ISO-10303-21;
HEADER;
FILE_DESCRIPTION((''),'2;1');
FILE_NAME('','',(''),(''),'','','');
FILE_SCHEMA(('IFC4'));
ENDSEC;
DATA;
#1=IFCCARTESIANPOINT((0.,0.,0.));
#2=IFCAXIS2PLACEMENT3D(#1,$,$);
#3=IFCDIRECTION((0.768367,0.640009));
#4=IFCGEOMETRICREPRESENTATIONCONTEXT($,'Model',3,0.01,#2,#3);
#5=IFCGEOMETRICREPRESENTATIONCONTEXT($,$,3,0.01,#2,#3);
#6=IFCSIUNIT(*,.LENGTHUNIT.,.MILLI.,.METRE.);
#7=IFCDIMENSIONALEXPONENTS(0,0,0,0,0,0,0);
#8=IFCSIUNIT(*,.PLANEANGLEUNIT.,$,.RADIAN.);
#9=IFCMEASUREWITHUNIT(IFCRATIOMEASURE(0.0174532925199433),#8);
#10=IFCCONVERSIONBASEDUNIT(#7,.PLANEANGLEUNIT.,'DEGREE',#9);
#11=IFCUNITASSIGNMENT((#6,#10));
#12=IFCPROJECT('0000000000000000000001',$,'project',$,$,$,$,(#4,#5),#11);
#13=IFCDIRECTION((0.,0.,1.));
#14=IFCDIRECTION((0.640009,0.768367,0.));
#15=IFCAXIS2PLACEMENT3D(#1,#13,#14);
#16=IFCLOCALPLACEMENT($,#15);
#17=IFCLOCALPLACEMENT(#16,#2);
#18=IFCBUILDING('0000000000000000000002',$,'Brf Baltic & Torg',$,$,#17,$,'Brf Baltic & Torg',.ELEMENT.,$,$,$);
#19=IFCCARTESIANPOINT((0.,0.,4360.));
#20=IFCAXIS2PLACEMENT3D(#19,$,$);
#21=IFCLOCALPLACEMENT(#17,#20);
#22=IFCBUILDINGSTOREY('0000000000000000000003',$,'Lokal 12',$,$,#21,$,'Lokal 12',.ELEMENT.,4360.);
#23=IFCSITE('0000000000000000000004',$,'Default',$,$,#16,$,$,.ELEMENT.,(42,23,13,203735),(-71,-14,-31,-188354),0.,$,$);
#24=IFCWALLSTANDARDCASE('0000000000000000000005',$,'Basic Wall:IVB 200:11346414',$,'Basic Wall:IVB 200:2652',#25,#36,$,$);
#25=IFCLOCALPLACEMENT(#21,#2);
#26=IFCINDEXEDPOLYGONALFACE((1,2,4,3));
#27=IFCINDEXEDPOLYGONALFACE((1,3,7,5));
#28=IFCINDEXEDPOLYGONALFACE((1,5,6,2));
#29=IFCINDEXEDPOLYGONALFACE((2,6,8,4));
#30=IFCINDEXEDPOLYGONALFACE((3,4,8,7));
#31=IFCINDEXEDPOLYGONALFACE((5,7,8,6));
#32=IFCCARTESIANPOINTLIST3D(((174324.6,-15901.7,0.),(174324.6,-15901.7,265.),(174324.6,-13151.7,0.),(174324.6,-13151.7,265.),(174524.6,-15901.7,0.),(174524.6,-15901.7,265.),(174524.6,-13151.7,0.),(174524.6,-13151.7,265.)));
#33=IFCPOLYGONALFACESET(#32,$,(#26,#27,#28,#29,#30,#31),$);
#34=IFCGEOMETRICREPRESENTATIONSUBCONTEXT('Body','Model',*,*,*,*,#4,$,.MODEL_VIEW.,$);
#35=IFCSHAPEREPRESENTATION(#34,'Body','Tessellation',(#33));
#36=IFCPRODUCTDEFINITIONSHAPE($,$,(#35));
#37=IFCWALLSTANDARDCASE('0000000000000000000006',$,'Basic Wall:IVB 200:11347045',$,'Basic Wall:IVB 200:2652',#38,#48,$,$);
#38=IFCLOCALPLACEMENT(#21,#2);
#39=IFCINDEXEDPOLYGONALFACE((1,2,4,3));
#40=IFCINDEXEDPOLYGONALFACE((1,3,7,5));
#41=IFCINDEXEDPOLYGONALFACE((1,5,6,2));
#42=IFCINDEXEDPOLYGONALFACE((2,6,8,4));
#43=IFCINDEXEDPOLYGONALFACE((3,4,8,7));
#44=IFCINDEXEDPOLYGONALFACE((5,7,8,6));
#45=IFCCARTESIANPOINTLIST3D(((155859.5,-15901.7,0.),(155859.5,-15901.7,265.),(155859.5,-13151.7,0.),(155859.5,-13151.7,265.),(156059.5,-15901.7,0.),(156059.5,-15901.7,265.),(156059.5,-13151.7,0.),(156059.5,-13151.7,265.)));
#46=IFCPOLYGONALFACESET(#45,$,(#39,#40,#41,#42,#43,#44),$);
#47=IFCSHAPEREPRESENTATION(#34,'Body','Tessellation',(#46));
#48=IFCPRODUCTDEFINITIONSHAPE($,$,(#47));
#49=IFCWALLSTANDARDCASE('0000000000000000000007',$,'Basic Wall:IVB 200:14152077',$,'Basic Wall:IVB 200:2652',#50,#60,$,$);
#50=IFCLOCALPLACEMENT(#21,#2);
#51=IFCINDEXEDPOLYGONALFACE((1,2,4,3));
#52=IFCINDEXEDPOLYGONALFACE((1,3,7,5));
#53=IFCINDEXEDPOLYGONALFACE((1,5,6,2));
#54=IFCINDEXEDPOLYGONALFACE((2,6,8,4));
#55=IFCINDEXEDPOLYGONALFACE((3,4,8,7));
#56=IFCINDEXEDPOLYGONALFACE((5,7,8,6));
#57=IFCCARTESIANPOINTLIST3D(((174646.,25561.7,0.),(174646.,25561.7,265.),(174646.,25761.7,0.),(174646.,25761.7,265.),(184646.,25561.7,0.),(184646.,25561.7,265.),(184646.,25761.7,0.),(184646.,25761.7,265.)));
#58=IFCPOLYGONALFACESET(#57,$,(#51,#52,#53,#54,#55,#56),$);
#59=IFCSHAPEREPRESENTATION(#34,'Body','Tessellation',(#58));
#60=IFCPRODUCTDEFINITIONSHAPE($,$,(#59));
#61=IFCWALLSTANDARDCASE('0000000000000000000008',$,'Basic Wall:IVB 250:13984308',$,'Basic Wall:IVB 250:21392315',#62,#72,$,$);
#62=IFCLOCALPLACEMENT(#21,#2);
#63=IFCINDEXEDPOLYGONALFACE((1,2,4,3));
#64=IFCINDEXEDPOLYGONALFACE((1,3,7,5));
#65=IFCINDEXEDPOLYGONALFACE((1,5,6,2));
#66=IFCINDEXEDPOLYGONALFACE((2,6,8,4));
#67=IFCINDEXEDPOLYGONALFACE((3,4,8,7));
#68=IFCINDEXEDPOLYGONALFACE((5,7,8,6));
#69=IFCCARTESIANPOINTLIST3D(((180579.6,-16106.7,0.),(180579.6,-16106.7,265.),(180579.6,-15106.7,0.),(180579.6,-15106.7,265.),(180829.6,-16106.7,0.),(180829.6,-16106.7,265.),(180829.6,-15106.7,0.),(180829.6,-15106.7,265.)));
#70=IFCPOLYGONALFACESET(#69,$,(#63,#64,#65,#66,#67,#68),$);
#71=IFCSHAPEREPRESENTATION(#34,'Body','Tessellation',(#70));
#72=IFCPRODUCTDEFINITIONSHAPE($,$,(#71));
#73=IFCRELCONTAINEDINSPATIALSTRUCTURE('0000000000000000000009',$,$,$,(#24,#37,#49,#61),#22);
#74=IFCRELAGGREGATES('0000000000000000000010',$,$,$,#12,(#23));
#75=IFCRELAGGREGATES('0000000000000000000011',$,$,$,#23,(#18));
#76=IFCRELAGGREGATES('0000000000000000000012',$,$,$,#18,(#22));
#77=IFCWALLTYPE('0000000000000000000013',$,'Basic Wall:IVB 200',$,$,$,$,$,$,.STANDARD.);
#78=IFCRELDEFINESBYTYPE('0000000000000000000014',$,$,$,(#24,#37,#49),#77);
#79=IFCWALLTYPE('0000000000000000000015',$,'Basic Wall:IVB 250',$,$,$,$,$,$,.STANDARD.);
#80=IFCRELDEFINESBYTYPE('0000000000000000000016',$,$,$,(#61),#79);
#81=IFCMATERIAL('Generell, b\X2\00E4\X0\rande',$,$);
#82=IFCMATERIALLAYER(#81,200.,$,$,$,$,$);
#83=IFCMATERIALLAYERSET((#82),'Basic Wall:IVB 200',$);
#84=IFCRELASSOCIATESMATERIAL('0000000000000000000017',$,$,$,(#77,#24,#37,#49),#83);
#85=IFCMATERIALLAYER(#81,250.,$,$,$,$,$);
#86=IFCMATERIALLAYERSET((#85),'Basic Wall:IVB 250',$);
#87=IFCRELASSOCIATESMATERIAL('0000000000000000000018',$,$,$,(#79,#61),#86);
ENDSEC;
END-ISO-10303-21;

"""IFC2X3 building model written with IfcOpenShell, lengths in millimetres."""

from ifc_helpers import new_model, entity, si_unit, converted_unit, direction, frame, frame_2d, origin, place, context, subcontext, project, spatial, rectangle, extrude, clip, halfspace, material, layer, layer_set, layer_usage, type_object, element, save


model = new_model("IFC2X3")

# Units and contexts
model_context = context("Model", 3, precision=0.01, world=origin(), true_north=direction((0.768367, 0.640009)))
context_of_model = context(None, 3, precision=0.01, world=origin(), true_north=direction((0.768367, 0.640009)))
body_context = subcontext(model_context, "Body", "Model", "MODEL_VIEW")
ifc_project = project(units=[si_unit("LENGTHUNIT", "METRE", prefix="MILLI"), converted_unit("PLANEANGLEUNIT", "DEGREE", entity("IfcRatioMeasure", 0.0174532925199433), si_unit("PLANEANGLEUNIT", "RADIAN"), dimensions=[0, 0, 0, 0, 0, 0, 0])], contexts=[model_context, context_of_model])

# Site, building, storey
site_placement = place(None, frame((0.0, 0.0, 0.0), z_axis=(0.0, 0.0, 1.0), x_axis=(0.640009, 0.768367, 0.0)))
site = spatial("IfcSite", under=ifc_project, at=site_placement, Name="Default", CompositionType="ELEMENT", RefLatitude=(42, 23, 13, 203735), RefLongitude=(-71, -14, -31, -188354), RefElevation=0.0)
building_placement = place(site_placement, origin())
building = spatial("IfcBuilding", under=site, at=building_placement, Name="Brf Baltic & Torg", LongName="Brf Baltic & Torg", CompositionType="ELEMENT")
storey_placement = place(building_placement, frame((0.0, 0.0, 4360.0)))
storey = spatial("IfcBuildingStorey", under=building, at=storey_placement, Name="Lokal 12", LongName="Lokal 12", CompositionType="ELEMENT", Elevation=4360.0)

# Shared definitions
ifc_material_1 = material(Name="Generell, bärande")
ifc_layer_1 = layer(ifc_material_1, 200.0)
ifc_layer_set_1 = layer_set([ifc_layer_1], Name="Basic Wall:IVB 200")
wall_type_1 = type_object("IfcWallType", Name="Basic Wall:IVB 200", PredefinedType="STANDARD", material=ifc_layer_set_1)

# Walls
ifc_layer_usage_1 = layer_usage(ifc_layer_set_1, "AXIS2", "POSITIVE", -100.0)
wall_1_placement = place(storey_placement, frame((174424.6, -15901.7, 0.0), z_axis=(0.0, 0.0, 1.0), x_axis=(0.0, 1.0, 0.0)))
element("IfcWallStandardCase", 1, at=wall_1_placement, inside=storey, type_object=wall_type_1, material=ifc_layer_usage_1, Name="Basic Wall:IVB 200:11346414", ObjectType="Basic Wall:IVB 200:2652", context=body_context, shape_type="Clipping", body=[
    clip(extrude(rectangle(XDim=2750.0, YDim=200.0, at=frame_2d((1375.0, 0.0), x_axis=(-1.0, 0.0))), origin(), (0.0, 0.0, 1.0), 265.0), halfspace(frame((0.0, 0.0, -2710.0)), True)),
])
ifc_layer_usage_2 = layer_usage(ifc_layer_set_1, "AXIS2", "NEGATIVE", 100.0)
wall_2_placement = place(storey_placement, frame((155959.5, -15901.7, 0.0), z_axis=(0.0, 0.0, 1.0), x_axis=(0.0, 1.0, 0.0)))
element("IfcWallStandardCase", 2, at=wall_2_placement, inside=storey, type_object=wall_type_1, material=ifc_layer_usage_2, Name="Basic Wall:IVB 200:11347045", ObjectType="Basic Wall:IVB 200:2652", context=body_context, shape_type="Clipping", body=[
    clip(extrude(rectangle(XDim=2750.0, YDim=200.0, at=frame_2d((1375.0, 0.0), x_axis=(-1.0, 0.0))), origin(), (0.0, 0.0, 1.0), 265.0), halfspace(frame((0.0, 0.0, -2710.0)), True)),
])

# Walls
ifc_layer_usage_3 = layer_usage(ifc_layer_set_1, "AXIS2", "NEGATIVE", 100.0)
wall_3_placement = place(storey_placement, frame((174646.0, 25661.7, 0.0)))
element("IfcWallStandardCase", 3, at=wall_3_placement, inside=storey, type_object=wall_type_1, material=ifc_layer_usage_3, Name="Basic Wall:IVB 200:14152077", ObjectType="Basic Wall:IVB 200:2652", context=body_context, shape_type="Clipping", body=[
    clip(extrude(rectangle(XDim=10000.0, YDim=200.0, at=frame_2d((5000.0, 0.0), x_axis=(-1.0, 0.0))), origin(), (0.0, 0.0, 1.0), 265.0), halfspace(frame((0.0, 0.0, -2710.0)), True)),
])
ifc_layer_2 = layer(ifc_material_1, 250.0)
ifc_layer_set_2 = layer_set([ifc_layer_2], Name="Basic Wall:IVB 250")
ifc_layer_usage_4 = layer_usage(ifc_layer_set_2, "AXIS2", "NEGATIVE", 125.0)
wall_type_2 = type_object("IfcWallType", Name="Basic Wall:IVB 250", PredefinedType="STANDARD", material=ifc_layer_set_2)
wall_4_placement = place(storey_placement, frame((180704.6, -15106.7, 0.0), z_axis=(0.0, 0.0, 1.0), x_axis=(0.0, -1.0, 0.0)))
element("IfcWallStandardCase", 4, at=wall_4_placement, inside=storey, type_object=wall_type_2, material=ifc_layer_usage_4, Name="Basic Wall:IVB 250:13984308", ObjectType="Basic Wall:IVB 250:21392315", context=body_context, shape_type="Clipping", body=[
    clip(extrude(rectangle(XDim=1000.0, YDim=250.0, at=frame_2d((500.0, 0.0), x_axis=(-1.0, 0.0))), origin(), (0.0, 0.0, 1.0), 265.0), halfspace(frame((0.0, 0.0, -2710.0)), True)),
])

save(model, "model.ifc")
